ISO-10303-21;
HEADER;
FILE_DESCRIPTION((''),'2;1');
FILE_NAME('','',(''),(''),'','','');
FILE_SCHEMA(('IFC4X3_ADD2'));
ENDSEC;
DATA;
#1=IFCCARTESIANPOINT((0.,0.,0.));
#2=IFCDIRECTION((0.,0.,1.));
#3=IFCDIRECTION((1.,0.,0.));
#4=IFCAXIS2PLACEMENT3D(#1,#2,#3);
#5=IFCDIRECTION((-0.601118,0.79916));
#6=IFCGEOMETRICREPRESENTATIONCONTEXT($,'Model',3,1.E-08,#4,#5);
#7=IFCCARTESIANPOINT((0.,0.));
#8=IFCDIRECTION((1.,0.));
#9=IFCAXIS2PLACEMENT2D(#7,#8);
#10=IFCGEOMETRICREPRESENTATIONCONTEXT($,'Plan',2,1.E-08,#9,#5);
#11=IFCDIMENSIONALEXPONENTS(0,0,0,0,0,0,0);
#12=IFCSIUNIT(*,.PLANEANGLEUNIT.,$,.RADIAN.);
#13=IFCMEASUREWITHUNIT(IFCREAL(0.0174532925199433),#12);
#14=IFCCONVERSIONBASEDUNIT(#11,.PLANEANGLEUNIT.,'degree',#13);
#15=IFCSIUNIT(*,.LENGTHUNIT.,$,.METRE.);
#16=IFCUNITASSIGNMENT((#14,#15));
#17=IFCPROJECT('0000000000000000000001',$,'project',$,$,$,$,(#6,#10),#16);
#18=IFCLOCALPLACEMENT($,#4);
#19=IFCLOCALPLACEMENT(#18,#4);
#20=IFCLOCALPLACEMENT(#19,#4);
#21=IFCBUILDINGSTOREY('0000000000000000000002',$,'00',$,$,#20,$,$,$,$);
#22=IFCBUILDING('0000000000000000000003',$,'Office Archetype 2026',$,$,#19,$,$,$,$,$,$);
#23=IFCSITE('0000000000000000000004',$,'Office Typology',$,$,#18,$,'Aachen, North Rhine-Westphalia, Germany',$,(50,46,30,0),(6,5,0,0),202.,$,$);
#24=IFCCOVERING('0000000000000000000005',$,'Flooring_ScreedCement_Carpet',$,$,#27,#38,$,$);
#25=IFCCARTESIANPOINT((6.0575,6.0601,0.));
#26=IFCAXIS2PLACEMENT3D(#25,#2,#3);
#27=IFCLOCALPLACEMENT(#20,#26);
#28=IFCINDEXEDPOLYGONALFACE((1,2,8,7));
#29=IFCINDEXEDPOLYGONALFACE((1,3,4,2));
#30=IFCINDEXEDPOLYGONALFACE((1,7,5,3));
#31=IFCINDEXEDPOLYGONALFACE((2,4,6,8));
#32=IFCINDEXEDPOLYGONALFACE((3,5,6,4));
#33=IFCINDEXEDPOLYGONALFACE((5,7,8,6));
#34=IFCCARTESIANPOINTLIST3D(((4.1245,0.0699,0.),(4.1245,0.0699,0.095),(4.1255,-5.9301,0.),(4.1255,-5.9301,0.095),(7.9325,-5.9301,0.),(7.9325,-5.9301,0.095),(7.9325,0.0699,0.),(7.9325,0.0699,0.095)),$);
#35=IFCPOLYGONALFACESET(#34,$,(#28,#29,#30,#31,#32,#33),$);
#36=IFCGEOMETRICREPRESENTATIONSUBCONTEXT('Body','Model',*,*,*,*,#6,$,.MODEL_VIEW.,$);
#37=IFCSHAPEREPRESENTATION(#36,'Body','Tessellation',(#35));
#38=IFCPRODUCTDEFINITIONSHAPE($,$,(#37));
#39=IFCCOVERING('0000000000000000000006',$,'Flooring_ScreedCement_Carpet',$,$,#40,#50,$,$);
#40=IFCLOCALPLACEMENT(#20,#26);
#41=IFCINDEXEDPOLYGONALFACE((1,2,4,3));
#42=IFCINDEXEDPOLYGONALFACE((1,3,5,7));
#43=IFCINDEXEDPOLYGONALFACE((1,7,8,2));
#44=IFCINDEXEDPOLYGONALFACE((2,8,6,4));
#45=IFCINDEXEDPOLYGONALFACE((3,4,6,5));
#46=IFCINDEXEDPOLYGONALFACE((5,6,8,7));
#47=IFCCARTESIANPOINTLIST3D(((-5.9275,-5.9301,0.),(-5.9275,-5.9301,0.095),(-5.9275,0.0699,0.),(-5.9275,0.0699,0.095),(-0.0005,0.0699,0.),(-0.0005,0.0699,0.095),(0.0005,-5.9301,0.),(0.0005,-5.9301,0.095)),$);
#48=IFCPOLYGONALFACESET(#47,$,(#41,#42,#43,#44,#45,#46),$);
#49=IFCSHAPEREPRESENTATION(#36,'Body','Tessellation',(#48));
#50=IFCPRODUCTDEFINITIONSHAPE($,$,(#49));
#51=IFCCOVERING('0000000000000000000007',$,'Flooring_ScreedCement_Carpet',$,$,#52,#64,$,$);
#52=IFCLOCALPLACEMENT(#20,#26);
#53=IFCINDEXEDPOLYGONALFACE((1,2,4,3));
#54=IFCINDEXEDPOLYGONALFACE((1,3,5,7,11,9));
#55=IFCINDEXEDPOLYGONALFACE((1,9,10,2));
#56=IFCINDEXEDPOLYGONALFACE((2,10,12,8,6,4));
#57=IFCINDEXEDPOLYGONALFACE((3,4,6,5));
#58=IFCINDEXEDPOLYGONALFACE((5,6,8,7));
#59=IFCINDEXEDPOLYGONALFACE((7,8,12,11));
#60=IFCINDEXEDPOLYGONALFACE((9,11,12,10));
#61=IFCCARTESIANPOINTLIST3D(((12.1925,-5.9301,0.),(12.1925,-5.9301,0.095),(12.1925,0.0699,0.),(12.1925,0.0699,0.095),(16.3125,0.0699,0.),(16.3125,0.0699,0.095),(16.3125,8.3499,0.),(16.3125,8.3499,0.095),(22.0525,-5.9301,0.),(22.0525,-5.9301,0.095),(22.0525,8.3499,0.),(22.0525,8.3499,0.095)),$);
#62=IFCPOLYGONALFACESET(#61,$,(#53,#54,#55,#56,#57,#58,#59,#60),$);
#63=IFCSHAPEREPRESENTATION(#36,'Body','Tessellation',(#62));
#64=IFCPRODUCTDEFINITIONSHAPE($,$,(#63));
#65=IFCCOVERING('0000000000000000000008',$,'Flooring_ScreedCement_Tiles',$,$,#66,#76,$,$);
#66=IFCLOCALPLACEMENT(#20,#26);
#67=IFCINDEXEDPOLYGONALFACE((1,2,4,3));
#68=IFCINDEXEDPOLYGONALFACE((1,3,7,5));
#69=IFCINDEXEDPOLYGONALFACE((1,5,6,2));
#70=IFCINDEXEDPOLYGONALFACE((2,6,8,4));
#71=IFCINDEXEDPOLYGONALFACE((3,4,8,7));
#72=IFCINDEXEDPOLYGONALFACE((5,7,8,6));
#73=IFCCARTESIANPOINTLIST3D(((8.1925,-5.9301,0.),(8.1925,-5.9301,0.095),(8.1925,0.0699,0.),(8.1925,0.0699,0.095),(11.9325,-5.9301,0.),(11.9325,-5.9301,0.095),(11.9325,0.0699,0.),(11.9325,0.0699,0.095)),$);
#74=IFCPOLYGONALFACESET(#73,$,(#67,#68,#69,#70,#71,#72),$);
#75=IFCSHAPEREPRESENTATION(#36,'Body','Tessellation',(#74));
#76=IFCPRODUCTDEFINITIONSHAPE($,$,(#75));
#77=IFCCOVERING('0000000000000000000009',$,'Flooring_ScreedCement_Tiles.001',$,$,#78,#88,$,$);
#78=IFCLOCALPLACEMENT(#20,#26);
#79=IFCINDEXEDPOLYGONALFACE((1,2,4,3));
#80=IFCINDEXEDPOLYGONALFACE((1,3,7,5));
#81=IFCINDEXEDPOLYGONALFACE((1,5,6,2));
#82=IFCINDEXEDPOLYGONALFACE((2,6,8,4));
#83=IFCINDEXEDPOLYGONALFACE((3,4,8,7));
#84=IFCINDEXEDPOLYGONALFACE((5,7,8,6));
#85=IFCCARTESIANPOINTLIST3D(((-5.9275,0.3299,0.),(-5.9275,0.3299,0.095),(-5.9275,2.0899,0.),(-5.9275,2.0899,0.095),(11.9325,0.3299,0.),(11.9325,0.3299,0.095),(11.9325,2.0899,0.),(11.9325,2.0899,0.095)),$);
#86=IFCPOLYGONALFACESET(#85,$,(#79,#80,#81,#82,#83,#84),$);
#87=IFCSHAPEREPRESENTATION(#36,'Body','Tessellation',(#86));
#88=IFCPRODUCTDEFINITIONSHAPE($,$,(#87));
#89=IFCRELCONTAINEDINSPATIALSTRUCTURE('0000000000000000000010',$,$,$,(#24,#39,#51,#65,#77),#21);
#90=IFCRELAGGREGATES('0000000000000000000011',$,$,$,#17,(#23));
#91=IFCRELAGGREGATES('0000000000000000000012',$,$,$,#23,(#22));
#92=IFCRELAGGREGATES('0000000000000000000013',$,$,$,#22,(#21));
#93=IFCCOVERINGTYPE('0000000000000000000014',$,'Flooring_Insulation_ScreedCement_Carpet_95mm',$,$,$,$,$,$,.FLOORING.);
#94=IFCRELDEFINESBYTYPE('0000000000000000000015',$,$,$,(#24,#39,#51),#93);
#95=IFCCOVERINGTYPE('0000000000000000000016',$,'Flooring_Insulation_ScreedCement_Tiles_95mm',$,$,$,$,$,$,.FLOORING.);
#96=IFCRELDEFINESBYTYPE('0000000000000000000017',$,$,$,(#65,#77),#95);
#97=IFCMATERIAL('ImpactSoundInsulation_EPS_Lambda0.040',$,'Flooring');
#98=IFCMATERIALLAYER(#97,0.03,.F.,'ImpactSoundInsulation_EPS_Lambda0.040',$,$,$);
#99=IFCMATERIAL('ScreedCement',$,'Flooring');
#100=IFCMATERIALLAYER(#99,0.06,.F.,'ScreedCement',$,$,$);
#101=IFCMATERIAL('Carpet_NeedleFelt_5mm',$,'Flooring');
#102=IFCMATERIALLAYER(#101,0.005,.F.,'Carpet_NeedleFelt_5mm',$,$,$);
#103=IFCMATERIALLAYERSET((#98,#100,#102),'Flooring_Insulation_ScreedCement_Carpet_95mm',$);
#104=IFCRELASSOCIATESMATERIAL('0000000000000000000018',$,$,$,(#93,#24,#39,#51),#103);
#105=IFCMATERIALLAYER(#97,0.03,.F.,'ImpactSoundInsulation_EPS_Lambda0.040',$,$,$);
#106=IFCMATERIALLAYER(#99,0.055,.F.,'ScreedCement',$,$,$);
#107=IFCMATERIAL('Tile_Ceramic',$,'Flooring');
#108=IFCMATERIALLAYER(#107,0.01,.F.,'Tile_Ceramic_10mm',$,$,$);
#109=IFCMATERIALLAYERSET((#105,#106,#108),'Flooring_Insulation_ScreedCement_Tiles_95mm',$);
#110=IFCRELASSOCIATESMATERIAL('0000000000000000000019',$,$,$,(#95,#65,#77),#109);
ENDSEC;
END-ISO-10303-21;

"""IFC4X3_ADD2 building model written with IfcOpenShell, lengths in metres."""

from ifc_helpers import new_model, entity, si_unit, converted_unit, direction, frame, origin_with_axes, origin_2d_with_axis, place, context, subcontext, project, spatial, line, indexed_curve, outline, extrude, material, layer, layer_set, layer_usage, type_object, element, save


model = new_model("IFC4X3_ADD2")

# Units and contexts
model_context = context("Model", 3, precision=1e-08, world=origin_with_axes(), true_north=direction((-0.601118, 0.79916)))
plan_context = context("Plan", 2, precision=1e-08, world=origin_2d_with_axis(), true_north=direction((-0.601118, 0.79916)))
body_context = subcontext(model_context, "Body", "Model", "MODEL_VIEW")
ifc_project = project(units=[converted_unit("PLANEANGLEUNIT", "degree", entity("IfcReal", 0.0174532925199433), si_unit("PLANEANGLEUNIT", "RADIAN"), dimensions=[0, 0, 0, 0, 0, 0, 0]), si_unit("LENGTHUNIT", "METRE")], contexts=[model_context, plan_context])

# Site, building, storey
site_placement = place(None, origin_with_axes())
site = spatial("IfcSite", under=ifc_project, at=site_placement, Name="Office Typology", LongName="Aachen, North Rhine-Westphalia, Germany", RefLatitude=(50, 46, 30, 0), RefLongitude=(6, 5, 0, 0), RefElevation=202.0)
building_placement = place(site_placement, origin_with_axes())
building = spatial("IfcBuilding", under=site, at=building_placement, Name="Office Archetype 2026")
storey_placement = place(building_placement, origin_with_axes())
storey = spatial("IfcBuildingStorey", under=building, at=storey_placement, Name="00")

# Coverings
ifc_material_1 = material(Name="ImpactSoundInsulation_EPS_Lambda0.040", Category="Flooring")
ifc_layer_1 = layer(ifc_material_1, 0.03, ventilated=False, Name="ImpactSoundInsulation_EPS_Lambda0.040")
ifc_material_2 = material(Name="ScreedCement", Category="Flooring")
ifc_layer_2 = layer(ifc_material_2, 0.06, ventilated=False, Name="ScreedCement")
ifc_material_3 = material(Name="Carpet_NeedleFelt_5mm", Category="Flooring")
ifc_layer_3 = layer(ifc_material_3, 0.005, ventilated=False, Name="Carpet_NeedleFelt_5mm")
ifc_layer_set_1 = layer_set([ifc_layer_1, ifc_layer_2, ifc_layer_3], Name="Flooring_Insulation_ScreedCement_Carpet_95mm")
ifc_layer_usage_1 = layer_usage(ifc_layer_set_1, "AXIS3", "POSITIVE", 0.0)
covering_type_1 = type_object("IfcCoveringType", Name="Flooring_Insulation_ScreedCement_Carpet_95mm", PredefinedType="FLOORING", material=ifc_layer_set_1)
covering_1_placement = place(storey_placement, frame((6.0575, 6.0601, 0.0), z_axis=(0.0, 0.0, 1.0), x_axis=(1.0, 0.0, 0.0)))
element("IfcCovering", 1, at=covering_1_placement, inside=storey, type_object=covering_type_1, material=ifc_layer_usage_1, Name="Flooring_ScreedCement_Carpet", context=body_context, shape_type="SweptSolid", body=[
    extrude(outline(indexed_curve([(4.1245, 0.0699), (7.9325, 0.0699), (7.9325, -5.9301), (4.1255, -5.9301)], segments=[line(1, 2, 3, 4, 1)])), origin_with_axes(), (0.0, 0.0, 1.0), 0.095),
])
ifc_layer_usage_2 = layer_usage(ifc_layer_set_1, "AXIS3", "POSITIVE", 0.0)
covering_2_placement = place(storey_placement, frame((6.0575, 6.0601, 0.0), z_axis=(0.0, 0.0, 1.0), x_axis=(1.0, 0.0, 0.0)))
element("IfcCovering", 2, at=covering_2_placement, inside=storey, type_object=covering_type_1, material=ifc_layer_usage_2, Name="Flooring_ScreedCement_Carpet", context=body_context, shape_type="SweptSolid", body=[
    extrude(outline(indexed_curve([(-5.9275, -5.9301), (-5.9275, 0.0699), (-0.0005, 0.0699), (0.0005, -5.9301)], segments=[line(1, 2, 3, 4, 1)])), origin_with_axes(), (0.0, 0.0, 1.0), 0.095),
])
ifc_layer_usage_3 = layer_usage(ifc_layer_set_1, "AXIS3", "POSITIVE", 0.0)
covering_3_placement = place(storey_placement, frame((6.0575, 6.0601, 0.0), z_axis=(0.0, 0.0, 1.0), x_axis=(1.0, 0.0, 0.0)))
element("IfcCovering", 3, at=covering_3_placement, inside=storey, type_object=covering_type_1, material=ifc_layer_usage_3, Name="Flooring_ScreedCement_Carpet", context=body_context, shape_type="SweptSolid", body=[
    extrude(outline(indexed_curve([(16.3125, 8.3499), (22.0525, 8.3499), (22.0525, -5.9301), (12.1925, -5.9301), (12.1925, 0.0699), (16.3125, 0.0699)], segments=[line(1, 2, 3, 4, 5, 6, 1)])), origin_with_axes(), (0.0, 0.0, 1.0), 0.095),
])
ifc_layer_4 = layer(ifc_material_1, 0.03, ventilated=False, Name="ImpactSoundInsulation_EPS_Lambda0.040")
ifc_layer_5 = layer(ifc_material_2, 0.055, ventilated=False, Name="ScreedCement")
ifc_material_4 = material(Name="Tile_Ceramic", Category="Flooring")
ifc_layer_6 = layer(ifc_material_4, 0.01, ventilated=False, Name="Tile_Ceramic_10mm")
ifc_layer_set_2 = layer_set([ifc_layer_4, ifc_layer_5, ifc_layer_6], Name="Flooring_Insulation_ScreedCement_Tiles_95mm")
ifc_layer_usage_4 = layer_usage(ifc_layer_set_2, "AXIS3", "POSITIVE", 0.0)
covering_type_2 = type_object("IfcCoveringType", Name="Flooring_Insulation_ScreedCement_Tiles_95mm", PredefinedType="FLOORING", material=ifc_layer_set_2)
covering_4_placement = place(storey_placement, frame((6.0575, 6.0601, 0.0), z_axis=(0.0, 0.0, 1.0), x_axis=(1.0, 0.0, 0.0)))
element("IfcCovering", 4, at=covering_4_placement, inside=storey, type_object=covering_type_2, material=ifc_layer_usage_4, Name="Flooring_ScreedCement_Tiles", context=body_context, shape_type="SweptSolid", body=[
    extrude(outline(indexed_curve([(8.1925, 0.0699), (11.9325, 0.0699), (11.9325, -5.9301), (8.1925, -5.9301)], segments=[line(1, 2, 3, 4, 1)])), origin_with_axes(), (0.0, 0.0, 1.0), 0.095),
])
ifc_layer_usage_5 = layer_usage(ifc_layer_set_2, "AXIS3", "POSITIVE", 0.0)
covering_5_placement = place(storey_placement, frame((6.0575, 6.0601, 0.0), z_axis=(0.0, 0.0, 1.0), x_axis=(1.0, 0.0, 0.0)))
element("IfcCovering", 5, at=covering_5_placement, inside=storey, type_object=covering_type_2, material=ifc_layer_usage_5, Name="Flooring_ScreedCement_Tiles.001", context=body_context, shape_type="SweptSolid", body=[
    extrude(outline(indexed_curve([(-5.9275, 0.3299), (-5.9275, 2.0899), (11.9325, 2.0899), (11.9325, 0.3299)], segments=[line(1, 2, 3, 4, 1)])), None, (0.0, 0.0, 1.0), 0.095),
])

save(model, "model.ifc")
